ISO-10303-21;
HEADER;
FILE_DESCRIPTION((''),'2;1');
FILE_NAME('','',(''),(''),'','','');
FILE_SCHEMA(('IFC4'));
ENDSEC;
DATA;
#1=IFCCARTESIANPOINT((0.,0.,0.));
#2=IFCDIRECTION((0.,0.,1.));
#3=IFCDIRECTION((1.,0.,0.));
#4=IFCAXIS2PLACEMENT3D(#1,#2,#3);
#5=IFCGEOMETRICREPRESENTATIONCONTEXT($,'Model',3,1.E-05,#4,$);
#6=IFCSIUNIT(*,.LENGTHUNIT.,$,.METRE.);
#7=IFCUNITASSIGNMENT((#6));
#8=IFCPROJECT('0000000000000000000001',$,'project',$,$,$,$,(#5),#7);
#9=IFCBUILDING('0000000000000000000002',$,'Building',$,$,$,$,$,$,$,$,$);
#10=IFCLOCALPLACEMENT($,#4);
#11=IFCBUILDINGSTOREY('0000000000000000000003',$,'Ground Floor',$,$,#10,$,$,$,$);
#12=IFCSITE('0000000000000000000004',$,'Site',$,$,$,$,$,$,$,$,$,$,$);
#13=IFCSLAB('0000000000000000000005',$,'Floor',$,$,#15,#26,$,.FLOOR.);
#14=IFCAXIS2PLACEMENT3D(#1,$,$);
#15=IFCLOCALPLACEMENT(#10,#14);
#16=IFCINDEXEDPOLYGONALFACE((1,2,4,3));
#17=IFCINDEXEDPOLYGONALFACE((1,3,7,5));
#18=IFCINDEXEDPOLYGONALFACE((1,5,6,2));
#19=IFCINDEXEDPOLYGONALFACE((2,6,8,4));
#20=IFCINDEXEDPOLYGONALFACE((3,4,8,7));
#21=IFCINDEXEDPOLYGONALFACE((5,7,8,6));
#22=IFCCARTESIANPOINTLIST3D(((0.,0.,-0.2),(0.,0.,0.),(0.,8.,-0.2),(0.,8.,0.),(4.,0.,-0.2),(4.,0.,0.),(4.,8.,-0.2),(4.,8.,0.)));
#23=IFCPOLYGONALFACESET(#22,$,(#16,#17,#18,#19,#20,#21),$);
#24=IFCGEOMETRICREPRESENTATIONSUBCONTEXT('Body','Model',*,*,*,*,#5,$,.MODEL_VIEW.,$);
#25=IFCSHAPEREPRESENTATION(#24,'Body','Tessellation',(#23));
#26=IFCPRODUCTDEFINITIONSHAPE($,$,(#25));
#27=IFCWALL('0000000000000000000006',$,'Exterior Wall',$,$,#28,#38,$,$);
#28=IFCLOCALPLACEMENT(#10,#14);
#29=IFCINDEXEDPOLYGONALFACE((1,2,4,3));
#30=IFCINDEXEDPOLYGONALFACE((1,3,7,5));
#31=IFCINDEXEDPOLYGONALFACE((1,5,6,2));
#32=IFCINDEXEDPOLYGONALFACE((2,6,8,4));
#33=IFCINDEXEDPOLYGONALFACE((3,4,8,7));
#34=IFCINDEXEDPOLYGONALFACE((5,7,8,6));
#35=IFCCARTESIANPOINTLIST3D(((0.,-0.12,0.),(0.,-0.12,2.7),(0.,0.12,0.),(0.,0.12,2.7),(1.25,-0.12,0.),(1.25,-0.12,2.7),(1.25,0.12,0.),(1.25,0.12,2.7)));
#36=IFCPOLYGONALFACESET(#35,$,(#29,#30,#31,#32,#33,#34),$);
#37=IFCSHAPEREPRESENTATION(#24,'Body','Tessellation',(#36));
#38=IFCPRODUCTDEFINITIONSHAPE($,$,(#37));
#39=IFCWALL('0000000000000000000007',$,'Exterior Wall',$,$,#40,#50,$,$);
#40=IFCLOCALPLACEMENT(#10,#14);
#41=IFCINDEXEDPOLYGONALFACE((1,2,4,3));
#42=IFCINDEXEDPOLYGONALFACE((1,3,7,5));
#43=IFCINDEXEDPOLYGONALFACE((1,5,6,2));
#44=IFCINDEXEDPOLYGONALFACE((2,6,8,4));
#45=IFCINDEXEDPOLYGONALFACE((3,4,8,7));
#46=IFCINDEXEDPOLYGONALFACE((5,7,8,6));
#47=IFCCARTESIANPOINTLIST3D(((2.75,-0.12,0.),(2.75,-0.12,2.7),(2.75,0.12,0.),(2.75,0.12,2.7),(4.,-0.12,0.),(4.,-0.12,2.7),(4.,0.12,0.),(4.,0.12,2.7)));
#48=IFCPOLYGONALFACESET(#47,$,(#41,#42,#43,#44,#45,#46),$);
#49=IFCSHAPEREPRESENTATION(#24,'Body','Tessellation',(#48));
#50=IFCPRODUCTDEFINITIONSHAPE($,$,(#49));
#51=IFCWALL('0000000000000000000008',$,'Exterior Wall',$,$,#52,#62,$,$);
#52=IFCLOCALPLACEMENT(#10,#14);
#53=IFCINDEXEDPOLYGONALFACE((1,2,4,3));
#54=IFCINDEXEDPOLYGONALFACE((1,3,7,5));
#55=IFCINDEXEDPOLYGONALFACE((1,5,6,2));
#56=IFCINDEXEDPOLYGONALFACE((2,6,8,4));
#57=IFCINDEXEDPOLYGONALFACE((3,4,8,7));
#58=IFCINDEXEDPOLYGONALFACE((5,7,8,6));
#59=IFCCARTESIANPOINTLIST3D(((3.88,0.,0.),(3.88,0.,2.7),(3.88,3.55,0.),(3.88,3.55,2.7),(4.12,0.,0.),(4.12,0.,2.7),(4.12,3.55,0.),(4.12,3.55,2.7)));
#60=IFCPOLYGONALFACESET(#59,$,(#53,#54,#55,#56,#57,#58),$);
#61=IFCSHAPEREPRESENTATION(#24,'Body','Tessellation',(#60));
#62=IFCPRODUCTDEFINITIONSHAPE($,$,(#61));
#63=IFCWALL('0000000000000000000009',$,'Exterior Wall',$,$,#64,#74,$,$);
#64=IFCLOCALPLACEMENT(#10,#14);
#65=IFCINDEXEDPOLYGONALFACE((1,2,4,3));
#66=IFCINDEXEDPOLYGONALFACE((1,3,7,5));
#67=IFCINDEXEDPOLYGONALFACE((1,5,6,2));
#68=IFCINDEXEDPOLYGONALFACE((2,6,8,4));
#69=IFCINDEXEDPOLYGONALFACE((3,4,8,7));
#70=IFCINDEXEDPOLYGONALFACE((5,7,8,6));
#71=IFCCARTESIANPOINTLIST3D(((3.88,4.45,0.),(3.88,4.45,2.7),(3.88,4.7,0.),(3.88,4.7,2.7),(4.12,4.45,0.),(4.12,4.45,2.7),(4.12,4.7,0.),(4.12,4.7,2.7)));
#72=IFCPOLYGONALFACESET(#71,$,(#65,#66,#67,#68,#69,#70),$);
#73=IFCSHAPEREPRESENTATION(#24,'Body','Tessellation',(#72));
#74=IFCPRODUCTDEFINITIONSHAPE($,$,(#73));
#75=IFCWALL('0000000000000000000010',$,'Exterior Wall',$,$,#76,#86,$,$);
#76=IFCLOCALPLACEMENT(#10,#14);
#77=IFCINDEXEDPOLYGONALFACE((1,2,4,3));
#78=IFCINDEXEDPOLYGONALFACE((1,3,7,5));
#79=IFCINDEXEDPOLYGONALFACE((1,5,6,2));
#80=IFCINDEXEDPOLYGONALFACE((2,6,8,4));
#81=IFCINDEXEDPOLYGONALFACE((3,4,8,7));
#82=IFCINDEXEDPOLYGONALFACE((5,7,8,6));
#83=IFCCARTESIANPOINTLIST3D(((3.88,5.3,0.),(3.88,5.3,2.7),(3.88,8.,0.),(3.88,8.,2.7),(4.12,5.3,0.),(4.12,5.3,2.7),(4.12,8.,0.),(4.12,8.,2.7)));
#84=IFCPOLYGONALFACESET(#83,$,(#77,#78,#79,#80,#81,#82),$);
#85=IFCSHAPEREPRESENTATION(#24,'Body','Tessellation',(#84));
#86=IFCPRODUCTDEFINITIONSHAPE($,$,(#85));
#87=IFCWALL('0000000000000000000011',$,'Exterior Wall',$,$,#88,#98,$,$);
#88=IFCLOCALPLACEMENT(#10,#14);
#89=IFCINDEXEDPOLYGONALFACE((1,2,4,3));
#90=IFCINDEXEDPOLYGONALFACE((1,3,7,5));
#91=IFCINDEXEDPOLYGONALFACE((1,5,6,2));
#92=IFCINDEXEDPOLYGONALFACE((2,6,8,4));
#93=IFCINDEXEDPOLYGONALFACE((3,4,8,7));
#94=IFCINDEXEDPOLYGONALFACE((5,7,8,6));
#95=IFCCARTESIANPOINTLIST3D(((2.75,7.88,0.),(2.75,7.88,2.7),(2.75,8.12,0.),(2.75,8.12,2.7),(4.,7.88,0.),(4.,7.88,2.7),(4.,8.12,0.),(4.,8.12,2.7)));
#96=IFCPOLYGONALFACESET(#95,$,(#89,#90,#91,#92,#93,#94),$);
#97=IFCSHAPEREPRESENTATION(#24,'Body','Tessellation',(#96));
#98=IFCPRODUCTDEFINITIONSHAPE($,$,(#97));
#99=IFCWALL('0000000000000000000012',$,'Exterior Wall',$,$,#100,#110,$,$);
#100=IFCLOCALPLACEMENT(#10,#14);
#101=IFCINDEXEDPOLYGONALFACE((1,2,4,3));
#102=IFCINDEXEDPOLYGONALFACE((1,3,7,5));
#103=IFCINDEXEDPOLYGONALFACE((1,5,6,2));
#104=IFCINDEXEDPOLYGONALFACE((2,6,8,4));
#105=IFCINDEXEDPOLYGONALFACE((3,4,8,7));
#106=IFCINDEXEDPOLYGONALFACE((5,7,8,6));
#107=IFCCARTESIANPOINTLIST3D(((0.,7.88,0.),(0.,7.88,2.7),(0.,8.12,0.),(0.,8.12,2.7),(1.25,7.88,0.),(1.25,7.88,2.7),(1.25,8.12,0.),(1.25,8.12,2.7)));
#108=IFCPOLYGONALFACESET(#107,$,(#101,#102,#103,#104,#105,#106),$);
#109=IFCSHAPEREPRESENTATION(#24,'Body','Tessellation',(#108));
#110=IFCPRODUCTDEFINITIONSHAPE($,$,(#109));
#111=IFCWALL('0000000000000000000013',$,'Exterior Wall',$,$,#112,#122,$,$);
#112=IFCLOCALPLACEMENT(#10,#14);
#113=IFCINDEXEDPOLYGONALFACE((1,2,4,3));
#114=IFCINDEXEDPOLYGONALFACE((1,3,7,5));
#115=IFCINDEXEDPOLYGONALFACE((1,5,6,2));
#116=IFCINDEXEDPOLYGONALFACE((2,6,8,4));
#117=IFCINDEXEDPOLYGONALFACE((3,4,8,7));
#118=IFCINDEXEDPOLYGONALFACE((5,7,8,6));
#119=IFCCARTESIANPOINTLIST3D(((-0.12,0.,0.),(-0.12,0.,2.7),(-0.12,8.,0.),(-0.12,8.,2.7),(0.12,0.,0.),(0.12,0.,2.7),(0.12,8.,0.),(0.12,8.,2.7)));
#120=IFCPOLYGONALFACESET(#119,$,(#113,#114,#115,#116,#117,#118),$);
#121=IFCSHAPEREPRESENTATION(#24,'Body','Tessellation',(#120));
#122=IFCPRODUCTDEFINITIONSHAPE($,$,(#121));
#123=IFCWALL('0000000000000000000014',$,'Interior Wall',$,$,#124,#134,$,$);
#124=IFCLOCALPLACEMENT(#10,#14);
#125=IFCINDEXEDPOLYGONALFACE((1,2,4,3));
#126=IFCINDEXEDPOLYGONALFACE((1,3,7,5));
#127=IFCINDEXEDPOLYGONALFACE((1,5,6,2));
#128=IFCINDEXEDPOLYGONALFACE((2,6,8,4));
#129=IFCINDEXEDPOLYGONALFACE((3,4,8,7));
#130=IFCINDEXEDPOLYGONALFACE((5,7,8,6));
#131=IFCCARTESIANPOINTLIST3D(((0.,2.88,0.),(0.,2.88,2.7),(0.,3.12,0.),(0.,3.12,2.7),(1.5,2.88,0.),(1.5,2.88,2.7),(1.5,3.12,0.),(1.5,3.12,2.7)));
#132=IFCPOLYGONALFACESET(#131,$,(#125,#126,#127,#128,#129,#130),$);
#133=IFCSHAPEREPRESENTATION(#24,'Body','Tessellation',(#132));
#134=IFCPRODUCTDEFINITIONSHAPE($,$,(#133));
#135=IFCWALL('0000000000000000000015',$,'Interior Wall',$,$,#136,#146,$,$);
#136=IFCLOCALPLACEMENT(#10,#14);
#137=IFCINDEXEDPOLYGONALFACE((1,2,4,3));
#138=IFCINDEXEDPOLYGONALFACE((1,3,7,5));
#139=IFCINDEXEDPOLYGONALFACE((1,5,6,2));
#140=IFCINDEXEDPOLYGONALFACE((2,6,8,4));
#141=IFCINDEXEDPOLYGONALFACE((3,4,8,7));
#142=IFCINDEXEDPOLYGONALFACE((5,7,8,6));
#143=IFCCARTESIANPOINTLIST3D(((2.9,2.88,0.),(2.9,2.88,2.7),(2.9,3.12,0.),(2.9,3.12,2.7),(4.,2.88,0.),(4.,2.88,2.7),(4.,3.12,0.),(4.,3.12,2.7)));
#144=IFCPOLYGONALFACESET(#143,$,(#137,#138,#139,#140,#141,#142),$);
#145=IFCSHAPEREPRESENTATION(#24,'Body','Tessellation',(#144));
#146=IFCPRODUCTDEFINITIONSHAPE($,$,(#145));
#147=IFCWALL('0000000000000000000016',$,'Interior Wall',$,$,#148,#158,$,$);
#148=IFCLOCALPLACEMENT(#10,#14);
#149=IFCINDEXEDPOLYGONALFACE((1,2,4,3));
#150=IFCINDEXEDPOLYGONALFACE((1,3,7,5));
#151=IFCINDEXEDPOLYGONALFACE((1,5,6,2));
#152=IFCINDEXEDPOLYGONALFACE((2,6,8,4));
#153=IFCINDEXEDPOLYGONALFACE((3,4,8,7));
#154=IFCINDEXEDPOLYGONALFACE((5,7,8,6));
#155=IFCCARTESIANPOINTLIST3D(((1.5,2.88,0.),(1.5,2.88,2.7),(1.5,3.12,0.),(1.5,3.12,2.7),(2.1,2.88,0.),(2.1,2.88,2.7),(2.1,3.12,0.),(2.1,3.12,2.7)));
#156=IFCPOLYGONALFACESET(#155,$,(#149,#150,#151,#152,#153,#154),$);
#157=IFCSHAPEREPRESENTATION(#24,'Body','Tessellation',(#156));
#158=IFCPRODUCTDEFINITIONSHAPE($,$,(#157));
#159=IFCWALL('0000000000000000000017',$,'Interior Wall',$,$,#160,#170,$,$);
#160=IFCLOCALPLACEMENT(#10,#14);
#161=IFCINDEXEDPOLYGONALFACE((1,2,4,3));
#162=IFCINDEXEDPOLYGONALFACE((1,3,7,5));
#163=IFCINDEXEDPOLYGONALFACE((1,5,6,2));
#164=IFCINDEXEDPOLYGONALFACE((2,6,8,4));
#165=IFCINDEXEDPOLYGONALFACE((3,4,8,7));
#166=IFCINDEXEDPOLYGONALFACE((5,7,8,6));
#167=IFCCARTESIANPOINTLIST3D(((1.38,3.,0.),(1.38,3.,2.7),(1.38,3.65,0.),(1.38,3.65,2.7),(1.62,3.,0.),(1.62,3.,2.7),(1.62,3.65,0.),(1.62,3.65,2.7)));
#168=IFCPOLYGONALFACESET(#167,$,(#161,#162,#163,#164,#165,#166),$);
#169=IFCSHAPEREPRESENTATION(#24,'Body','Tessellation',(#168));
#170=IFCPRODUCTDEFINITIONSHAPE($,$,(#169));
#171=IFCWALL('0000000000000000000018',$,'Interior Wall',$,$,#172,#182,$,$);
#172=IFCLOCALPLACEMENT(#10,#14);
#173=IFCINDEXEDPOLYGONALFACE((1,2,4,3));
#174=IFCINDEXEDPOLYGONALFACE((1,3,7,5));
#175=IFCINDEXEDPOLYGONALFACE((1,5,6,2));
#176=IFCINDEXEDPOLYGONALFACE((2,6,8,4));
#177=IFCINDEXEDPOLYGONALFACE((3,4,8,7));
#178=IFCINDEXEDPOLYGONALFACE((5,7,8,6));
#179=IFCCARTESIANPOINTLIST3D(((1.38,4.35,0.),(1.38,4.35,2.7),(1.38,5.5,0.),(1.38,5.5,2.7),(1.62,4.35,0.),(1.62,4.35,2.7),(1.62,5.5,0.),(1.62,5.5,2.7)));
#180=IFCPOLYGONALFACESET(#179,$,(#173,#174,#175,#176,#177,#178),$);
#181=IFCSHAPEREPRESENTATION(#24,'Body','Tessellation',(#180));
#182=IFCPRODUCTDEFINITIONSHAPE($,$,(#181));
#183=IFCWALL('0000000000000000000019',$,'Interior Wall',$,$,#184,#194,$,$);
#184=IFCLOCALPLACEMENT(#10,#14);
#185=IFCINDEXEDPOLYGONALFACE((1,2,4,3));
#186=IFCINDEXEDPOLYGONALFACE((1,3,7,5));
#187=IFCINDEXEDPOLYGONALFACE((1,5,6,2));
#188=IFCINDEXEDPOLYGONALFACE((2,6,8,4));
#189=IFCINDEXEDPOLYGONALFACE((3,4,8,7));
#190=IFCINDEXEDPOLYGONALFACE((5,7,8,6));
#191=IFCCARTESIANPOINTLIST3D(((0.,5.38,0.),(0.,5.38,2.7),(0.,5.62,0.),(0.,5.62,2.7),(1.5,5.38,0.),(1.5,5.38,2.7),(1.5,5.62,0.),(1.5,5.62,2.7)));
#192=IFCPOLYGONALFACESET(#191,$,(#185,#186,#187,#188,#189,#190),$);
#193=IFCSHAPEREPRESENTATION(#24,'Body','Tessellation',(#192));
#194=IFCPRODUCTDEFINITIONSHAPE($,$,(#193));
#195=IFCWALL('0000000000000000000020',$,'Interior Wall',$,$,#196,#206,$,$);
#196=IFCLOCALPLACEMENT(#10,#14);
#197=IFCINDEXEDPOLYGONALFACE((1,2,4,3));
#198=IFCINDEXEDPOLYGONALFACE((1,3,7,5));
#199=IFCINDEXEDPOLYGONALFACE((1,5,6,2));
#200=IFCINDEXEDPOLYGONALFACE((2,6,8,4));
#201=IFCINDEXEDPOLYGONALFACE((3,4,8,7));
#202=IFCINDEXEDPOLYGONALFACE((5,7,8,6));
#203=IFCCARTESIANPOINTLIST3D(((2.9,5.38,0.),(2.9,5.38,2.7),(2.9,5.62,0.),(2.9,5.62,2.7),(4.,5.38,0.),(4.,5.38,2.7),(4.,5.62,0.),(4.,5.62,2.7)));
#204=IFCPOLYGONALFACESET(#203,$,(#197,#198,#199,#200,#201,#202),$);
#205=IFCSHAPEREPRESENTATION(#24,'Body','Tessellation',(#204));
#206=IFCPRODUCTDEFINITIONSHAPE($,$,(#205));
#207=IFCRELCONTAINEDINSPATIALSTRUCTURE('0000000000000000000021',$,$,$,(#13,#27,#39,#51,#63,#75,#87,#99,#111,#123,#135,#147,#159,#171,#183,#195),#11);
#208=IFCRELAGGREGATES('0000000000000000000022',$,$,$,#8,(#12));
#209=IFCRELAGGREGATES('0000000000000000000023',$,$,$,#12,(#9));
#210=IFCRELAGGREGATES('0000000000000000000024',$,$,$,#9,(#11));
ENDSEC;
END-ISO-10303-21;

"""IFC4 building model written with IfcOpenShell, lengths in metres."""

from ifc_helpers import new_model, si_unit, frame, origin_with_axes, place, context, subcontext, project, spatial, indexed_curve, outline, extrude, element, save


model = new_model("IFC4")

# Units and contexts
model_context = context("Model", 3, precision=1e-05, world=origin_with_axes())
body_context = subcontext(model_context, "Body", "Model", "MODEL_VIEW")
ifc_project = project(units=[si_unit("LENGTHUNIT", "METRE")], contexts=[model_context])

# Site, building, storey
site = spatial("IfcSite", under=ifc_project, Name="Site")
building = spatial("IfcBuilding", under=site, Name="Building")
storey_placement = place(None, origin_with_axes())
storey = spatial("IfcBuildingStorey", under=building, at=storey_placement, Name="Ground Floor")

# Slab
slab_placement = place(storey_placement, frame((0.0, 0.0, -0.2), z_axis=(0.0, 0.0, 1.0), x_axis=(1.0, 0.0, 0.0)))
element("IfcSlab", 1, at=slab_placement, inside=storey, Name="Floor", PredefinedType="FLOOR", context=body_context, shape_type="SweptSolid", body=[
    extrude(outline(indexed_curve([(0.0, 0.0), (4.0, 0.0), (4.0, 8.0), (0.0, 8.0)])), None, (0.0, 0.0, 1.0), 0.2),
])

# Walls
for number, where, z_axis, x_axis, name in (
    (2, (0.0, 0.0, 0.0), (0.0, 0.0, 1.0), (1.0, 0.0, 0.0), "Exterior Wall"),
    (3, (2.75, 0.0, 0.0), (0.0, 0.0, 1.0), (1.0, 0.0, 0.0), "Exterior Wall"),
):
    element("IfcWall", number, at=place(storey_placement, frame(where, z_axis=z_axis, x_axis=x_axis)), inside=storey, Name=name, context=body_context, shape_type="SweptSolid", body=[
        extrude(outline(indexed_curve([(0.0, 0.0), (0.0, 0.24), (1.25, 0.24), (1.25, 0.0), (0.0, 0.0)], self_intersect=False)), frame((0.0, -0.12, 0.0), z_axis=(0.0, 0.0, 1.0), x_axis=(1.0, 0.0, 0.0)), (0.0, 0.0, 1.0), 2.7),
    ])
wall_1_placement = place(storey_placement, frame((4.0, 0.0, 0.0), z_axis=(0.0, 0.0, 1.0), x_axis=(0.0, 1.0, 0.0)))
element("IfcWall", 4, at=wall_1_placement, inside=storey, Name="Exterior Wall", context=body_context, shape_type="SweptSolid", body=[
    extrude(outline(indexed_curve([(0.0, 0.0), (0.0, 0.24), (3.55, 0.24), (3.55, 0.0), (0.0, 0.0)], self_intersect=False)), frame((0.0, -0.12, 0.0), z_axis=(0.0, 0.0, 1.0), x_axis=(1.0, 0.0, 0.0)), (0.0, 0.0, 1.0), 2.7),
])
wall_2_placement = place(storey_placement, frame((4.0, 4.45, 0.0), z_axis=(0.0, 0.0, 1.0), x_axis=(0.0, 1.0, 0.0)))
element("IfcWall", 5, at=wall_2_placement, inside=storey, Name="Exterior Wall", context=body_context, shape_type="SweptSolid", body=[
    extrude(outline(indexed_curve([(0.0, 0.0), (0.0, 0.24), (0.25, 0.24), (0.25, 0.0), (0.0, 0.0)], self_intersect=False)), frame((0.0, -0.12, 0.0), z_axis=(0.0, 0.0, 1.0), x_axis=(1.0, 0.0, 0.0)), (0.0, 0.0, 1.0), 2.7),
])
wall_3_placement = place(storey_placement, frame((4.0, 5.3, 0.0), z_axis=(0.0, 0.0, 1.0), x_axis=(0.0, 1.0, 0.0)))
element("IfcWall", 6, at=wall_3_placement, inside=storey, Name="Exterior Wall", context=body_context, shape_type="SweptSolid", body=[
    extrude(outline(indexed_curve([(0.0, 0.0), (0.0, 0.24), (2.7, 0.24), (2.7, 0.0), (0.0, 0.0)], self_intersect=False)), frame((0.0, -0.12, 0.0), z_axis=(0.0, 0.0, 1.0), x_axis=(1.0, 0.0, 0.0)), (0.0, 0.0, 1.0), 2.7),
])
for number, where, z_axis, x_axis, name in (
    (7, (4.0, 8.0, 0.0), (0.0, 0.0, 1.0), (-1.0, 0.0, 0.0), "Exterior Wall"),
    (8, (1.25, 8.0, 0.0), (0.0, 0.0, 1.0), (-1.0, 0.0, 0.0), "Exterior Wall"),
):
    element("IfcWall", number, at=place(storey_placement, frame(where, z_axis=z_axis, x_axis=x_axis)), inside=storey, Name=name, context=body_context, shape_type="SweptSolid", body=[
        extrude(outline(indexed_curve([(0.0, 0.0), (0.0, 0.24), (1.25, 0.24), (1.25, 0.0), (0.0, 0.0)], self_intersect=False)), frame((0.0, -0.12, 0.0), z_axis=(0.0, 0.0, 1.0), x_axis=(1.0, 0.0, 0.0)), (0.0, 0.0, 1.0), 2.7),
    ])
wall_4_placement = place(storey_placement, frame((0.0, 8.0, 0.0), z_axis=(0.0, 0.0, 1.0), x_axis=(0.0, -1.0, 0.0)))
element("IfcWall", 9, at=wall_4_placement, inside=storey, Name="Exterior Wall", context=body_context, shape_type="SweptSolid", body=[
    extrude(outline(indexed_curve([(0.0, 0.0), (0.0, 0.24), (8.0, 0.24), (8.0, 0.0), (0.0, 0.0)], self_intersect=False)), frame((0.0, -0.12, 0.0), z_axis=(0.0, 0.0, 1.0), x_axis=(1.0, 0.0, 0.0)), (0.0, 0.0, 1.0), 2.7),
])
wall_5_placement = place(storey_placement, frame((1.5, 3.0, 0.0), z_axis=(0.0, 0.0, 1.0), x_axis=(-1.0, 0.0, 0.0)))
element("IfcWall", 10, at=wall_5_placement, inside=storey, Name="Interior Wall", context=body_context, shape_type="SweptSolid", body=[
    extrude(outline(indexed_curve([(0.0, 0.0), (0.0, 0.24), (1.5, 0.24), (1.5, 0.0), (0.0, 0.0)], self_intersect=False)), frame((0.0, -0.12, 0.0), z_axis=(0.0, 0.0, 1.0), x_axis=(1.0, 0.0, 0.0)), (0.0, 0.0, 1.0), 2.7),
])
wall_6_placement = place(storey_placement, frame((4.0, 3.0, 0.0), z_axis=(0.0, 0.0, 1.0), x_axis=(-1.0, 0.0, 0.0)))
element("IfcWall", 11, at=wall_6_placement, inside=storey, Name="Interior Wall", context=body_context, shape_type="SweptSolid", body=[
    extrude(outline(indexed_curve([(0.0, 0.0), (0.0, 0.24), (1.1, 0.24), (1.1, 0.0), (0.0, 0.0)], self_intersect=False)), frame((0.0, -0.12, 0.0), z_axis=(0.0, 0.0, 1.0), x_axis=(1.0, 0.0, 0.0)), (0.0, 0.0, 1.0), 2.7),
])
wall_7_placement = place(storey_placement, frame((2.1, 3.0, 0.0), z_axis=(0.0, 0.0, 1.0), x_axis=(-1.0, 0.0, 0.0)))
element("IfcWall", 12, at=wall_7_placement, inside=storey, Name="Interior Wall", context=body_context, shape_type="SweptSolid", body=[
    extrude(outline(indexed_curve([(0.0, 0.0), (0.0, 0.24), (0.6, 0.24), (0.6, 0.0), (0.0, 0.0)], self_intersect=False)), frame((0.0, -0.12, 0.0), z_axis=(0.0, 0.0, 1.0), x_axis=(1.0, 0.0, 0.0)), (0.0, 0.0, 1.0), 2.7),
])
wall_8_placement = place(storey_placement, frame((1.5, 3.0, 0.0), z_axis=(0.0, 0.0, 1.0), x_axis=(0.0, 1.0, 0.0)))
element("IfcWall", 13, at=wall_8_placement, inside=storey, Name="Interior Wall", context=body_context, shape_type="SweptSolid", body=[
    extrude(outline(indexed_curve([(0.0, 0.0), (0.0, 0.24), (0.65, 0.24), (0.65, 0.0), (0.0, 0.0)], self_intersect=False)), frame((0.0, -0.12, 0.0), z_axis=(0.0, 0.0, 1.0), x_axis=(1.0, 0.0, 0.0)), (0.0, 0.0, 1.0), 2.7),
])
wall_9_placement = place(storey_placement, frame((1.5, 4.35, 0.0), z_axis=(0.0, 0.0, 1.0), x_axis=(0.0, 1.0, 0.0)))
element("IfcWall", 14, at=wall_9_placement, inside=storey, Name="Interior Wall", context=body_context, shape_type="SweptSolid", body=[
    extrude(outline(indexed_curve([(0.0, 0.0), (0.0, 0.24), (1.15, 0.24), (1.15, 0.0), (0.0, 0.0)], self_intersect=False)), frame((0.0, -0.12, 0.0), z_axis=(0.0, 0.0, 1.0), x_axis=(1.0, 0.0, 0.0)), (0.0, 0.0, 1.0), 2.7),
])
wall_10_placement = place(storey_placement, frame((1.5, 5.5, 0.0), z_axis=(0.0, 0.0, 1.0), x_axis=(-1.0, 0.0, 0.0)))
element("IfcWall", 15, at=wall_10_placement, inside=storey, Name="Interior Wall", context=body_context, shape_type="SweptSolid", body=[
    extrude(outline(indexed_curve([(0.0, 0.0), (0.0, 0.24), (1.5, 0.24), (1.5, 0.0), (0.0, 0.0)], self_intersect=False)), frame((0.0, -0.12, 0.0), z_axis=(0.0, 0.0, 1.0), x_axis=(1.0, 0.0, 0.0)), (0.0, 0.0, 1.0), 2.7),
])
wall_11_placement = place(storey_placement, frame((4.0, 5.5, 0.0), z_axis=(0.0, 0.0, 1.0), x_axis=(-1.0, 0.0, 0.0)))
element("IfcWall", 16, at=wall_11_placement, inside=storey, Name="Interior Wall", context=body_context, shape_type="SweptSolid", body=[
    extrude(outline(indexed_curve([(0.0, 0.0), (0.0, 0.24), (1.1, 0.24), (1.1, 0.0), (0.0, 0.0)], self_intersect=False)), frame((0.0, -0.12, 0.0), z_axis=(0.0, 0.0, 1.0), x_axis=(1.0, 0.0, 0.0)), (0.0, 0.0, 1.0), 2.7),
])

save(model, "model.ifc")
